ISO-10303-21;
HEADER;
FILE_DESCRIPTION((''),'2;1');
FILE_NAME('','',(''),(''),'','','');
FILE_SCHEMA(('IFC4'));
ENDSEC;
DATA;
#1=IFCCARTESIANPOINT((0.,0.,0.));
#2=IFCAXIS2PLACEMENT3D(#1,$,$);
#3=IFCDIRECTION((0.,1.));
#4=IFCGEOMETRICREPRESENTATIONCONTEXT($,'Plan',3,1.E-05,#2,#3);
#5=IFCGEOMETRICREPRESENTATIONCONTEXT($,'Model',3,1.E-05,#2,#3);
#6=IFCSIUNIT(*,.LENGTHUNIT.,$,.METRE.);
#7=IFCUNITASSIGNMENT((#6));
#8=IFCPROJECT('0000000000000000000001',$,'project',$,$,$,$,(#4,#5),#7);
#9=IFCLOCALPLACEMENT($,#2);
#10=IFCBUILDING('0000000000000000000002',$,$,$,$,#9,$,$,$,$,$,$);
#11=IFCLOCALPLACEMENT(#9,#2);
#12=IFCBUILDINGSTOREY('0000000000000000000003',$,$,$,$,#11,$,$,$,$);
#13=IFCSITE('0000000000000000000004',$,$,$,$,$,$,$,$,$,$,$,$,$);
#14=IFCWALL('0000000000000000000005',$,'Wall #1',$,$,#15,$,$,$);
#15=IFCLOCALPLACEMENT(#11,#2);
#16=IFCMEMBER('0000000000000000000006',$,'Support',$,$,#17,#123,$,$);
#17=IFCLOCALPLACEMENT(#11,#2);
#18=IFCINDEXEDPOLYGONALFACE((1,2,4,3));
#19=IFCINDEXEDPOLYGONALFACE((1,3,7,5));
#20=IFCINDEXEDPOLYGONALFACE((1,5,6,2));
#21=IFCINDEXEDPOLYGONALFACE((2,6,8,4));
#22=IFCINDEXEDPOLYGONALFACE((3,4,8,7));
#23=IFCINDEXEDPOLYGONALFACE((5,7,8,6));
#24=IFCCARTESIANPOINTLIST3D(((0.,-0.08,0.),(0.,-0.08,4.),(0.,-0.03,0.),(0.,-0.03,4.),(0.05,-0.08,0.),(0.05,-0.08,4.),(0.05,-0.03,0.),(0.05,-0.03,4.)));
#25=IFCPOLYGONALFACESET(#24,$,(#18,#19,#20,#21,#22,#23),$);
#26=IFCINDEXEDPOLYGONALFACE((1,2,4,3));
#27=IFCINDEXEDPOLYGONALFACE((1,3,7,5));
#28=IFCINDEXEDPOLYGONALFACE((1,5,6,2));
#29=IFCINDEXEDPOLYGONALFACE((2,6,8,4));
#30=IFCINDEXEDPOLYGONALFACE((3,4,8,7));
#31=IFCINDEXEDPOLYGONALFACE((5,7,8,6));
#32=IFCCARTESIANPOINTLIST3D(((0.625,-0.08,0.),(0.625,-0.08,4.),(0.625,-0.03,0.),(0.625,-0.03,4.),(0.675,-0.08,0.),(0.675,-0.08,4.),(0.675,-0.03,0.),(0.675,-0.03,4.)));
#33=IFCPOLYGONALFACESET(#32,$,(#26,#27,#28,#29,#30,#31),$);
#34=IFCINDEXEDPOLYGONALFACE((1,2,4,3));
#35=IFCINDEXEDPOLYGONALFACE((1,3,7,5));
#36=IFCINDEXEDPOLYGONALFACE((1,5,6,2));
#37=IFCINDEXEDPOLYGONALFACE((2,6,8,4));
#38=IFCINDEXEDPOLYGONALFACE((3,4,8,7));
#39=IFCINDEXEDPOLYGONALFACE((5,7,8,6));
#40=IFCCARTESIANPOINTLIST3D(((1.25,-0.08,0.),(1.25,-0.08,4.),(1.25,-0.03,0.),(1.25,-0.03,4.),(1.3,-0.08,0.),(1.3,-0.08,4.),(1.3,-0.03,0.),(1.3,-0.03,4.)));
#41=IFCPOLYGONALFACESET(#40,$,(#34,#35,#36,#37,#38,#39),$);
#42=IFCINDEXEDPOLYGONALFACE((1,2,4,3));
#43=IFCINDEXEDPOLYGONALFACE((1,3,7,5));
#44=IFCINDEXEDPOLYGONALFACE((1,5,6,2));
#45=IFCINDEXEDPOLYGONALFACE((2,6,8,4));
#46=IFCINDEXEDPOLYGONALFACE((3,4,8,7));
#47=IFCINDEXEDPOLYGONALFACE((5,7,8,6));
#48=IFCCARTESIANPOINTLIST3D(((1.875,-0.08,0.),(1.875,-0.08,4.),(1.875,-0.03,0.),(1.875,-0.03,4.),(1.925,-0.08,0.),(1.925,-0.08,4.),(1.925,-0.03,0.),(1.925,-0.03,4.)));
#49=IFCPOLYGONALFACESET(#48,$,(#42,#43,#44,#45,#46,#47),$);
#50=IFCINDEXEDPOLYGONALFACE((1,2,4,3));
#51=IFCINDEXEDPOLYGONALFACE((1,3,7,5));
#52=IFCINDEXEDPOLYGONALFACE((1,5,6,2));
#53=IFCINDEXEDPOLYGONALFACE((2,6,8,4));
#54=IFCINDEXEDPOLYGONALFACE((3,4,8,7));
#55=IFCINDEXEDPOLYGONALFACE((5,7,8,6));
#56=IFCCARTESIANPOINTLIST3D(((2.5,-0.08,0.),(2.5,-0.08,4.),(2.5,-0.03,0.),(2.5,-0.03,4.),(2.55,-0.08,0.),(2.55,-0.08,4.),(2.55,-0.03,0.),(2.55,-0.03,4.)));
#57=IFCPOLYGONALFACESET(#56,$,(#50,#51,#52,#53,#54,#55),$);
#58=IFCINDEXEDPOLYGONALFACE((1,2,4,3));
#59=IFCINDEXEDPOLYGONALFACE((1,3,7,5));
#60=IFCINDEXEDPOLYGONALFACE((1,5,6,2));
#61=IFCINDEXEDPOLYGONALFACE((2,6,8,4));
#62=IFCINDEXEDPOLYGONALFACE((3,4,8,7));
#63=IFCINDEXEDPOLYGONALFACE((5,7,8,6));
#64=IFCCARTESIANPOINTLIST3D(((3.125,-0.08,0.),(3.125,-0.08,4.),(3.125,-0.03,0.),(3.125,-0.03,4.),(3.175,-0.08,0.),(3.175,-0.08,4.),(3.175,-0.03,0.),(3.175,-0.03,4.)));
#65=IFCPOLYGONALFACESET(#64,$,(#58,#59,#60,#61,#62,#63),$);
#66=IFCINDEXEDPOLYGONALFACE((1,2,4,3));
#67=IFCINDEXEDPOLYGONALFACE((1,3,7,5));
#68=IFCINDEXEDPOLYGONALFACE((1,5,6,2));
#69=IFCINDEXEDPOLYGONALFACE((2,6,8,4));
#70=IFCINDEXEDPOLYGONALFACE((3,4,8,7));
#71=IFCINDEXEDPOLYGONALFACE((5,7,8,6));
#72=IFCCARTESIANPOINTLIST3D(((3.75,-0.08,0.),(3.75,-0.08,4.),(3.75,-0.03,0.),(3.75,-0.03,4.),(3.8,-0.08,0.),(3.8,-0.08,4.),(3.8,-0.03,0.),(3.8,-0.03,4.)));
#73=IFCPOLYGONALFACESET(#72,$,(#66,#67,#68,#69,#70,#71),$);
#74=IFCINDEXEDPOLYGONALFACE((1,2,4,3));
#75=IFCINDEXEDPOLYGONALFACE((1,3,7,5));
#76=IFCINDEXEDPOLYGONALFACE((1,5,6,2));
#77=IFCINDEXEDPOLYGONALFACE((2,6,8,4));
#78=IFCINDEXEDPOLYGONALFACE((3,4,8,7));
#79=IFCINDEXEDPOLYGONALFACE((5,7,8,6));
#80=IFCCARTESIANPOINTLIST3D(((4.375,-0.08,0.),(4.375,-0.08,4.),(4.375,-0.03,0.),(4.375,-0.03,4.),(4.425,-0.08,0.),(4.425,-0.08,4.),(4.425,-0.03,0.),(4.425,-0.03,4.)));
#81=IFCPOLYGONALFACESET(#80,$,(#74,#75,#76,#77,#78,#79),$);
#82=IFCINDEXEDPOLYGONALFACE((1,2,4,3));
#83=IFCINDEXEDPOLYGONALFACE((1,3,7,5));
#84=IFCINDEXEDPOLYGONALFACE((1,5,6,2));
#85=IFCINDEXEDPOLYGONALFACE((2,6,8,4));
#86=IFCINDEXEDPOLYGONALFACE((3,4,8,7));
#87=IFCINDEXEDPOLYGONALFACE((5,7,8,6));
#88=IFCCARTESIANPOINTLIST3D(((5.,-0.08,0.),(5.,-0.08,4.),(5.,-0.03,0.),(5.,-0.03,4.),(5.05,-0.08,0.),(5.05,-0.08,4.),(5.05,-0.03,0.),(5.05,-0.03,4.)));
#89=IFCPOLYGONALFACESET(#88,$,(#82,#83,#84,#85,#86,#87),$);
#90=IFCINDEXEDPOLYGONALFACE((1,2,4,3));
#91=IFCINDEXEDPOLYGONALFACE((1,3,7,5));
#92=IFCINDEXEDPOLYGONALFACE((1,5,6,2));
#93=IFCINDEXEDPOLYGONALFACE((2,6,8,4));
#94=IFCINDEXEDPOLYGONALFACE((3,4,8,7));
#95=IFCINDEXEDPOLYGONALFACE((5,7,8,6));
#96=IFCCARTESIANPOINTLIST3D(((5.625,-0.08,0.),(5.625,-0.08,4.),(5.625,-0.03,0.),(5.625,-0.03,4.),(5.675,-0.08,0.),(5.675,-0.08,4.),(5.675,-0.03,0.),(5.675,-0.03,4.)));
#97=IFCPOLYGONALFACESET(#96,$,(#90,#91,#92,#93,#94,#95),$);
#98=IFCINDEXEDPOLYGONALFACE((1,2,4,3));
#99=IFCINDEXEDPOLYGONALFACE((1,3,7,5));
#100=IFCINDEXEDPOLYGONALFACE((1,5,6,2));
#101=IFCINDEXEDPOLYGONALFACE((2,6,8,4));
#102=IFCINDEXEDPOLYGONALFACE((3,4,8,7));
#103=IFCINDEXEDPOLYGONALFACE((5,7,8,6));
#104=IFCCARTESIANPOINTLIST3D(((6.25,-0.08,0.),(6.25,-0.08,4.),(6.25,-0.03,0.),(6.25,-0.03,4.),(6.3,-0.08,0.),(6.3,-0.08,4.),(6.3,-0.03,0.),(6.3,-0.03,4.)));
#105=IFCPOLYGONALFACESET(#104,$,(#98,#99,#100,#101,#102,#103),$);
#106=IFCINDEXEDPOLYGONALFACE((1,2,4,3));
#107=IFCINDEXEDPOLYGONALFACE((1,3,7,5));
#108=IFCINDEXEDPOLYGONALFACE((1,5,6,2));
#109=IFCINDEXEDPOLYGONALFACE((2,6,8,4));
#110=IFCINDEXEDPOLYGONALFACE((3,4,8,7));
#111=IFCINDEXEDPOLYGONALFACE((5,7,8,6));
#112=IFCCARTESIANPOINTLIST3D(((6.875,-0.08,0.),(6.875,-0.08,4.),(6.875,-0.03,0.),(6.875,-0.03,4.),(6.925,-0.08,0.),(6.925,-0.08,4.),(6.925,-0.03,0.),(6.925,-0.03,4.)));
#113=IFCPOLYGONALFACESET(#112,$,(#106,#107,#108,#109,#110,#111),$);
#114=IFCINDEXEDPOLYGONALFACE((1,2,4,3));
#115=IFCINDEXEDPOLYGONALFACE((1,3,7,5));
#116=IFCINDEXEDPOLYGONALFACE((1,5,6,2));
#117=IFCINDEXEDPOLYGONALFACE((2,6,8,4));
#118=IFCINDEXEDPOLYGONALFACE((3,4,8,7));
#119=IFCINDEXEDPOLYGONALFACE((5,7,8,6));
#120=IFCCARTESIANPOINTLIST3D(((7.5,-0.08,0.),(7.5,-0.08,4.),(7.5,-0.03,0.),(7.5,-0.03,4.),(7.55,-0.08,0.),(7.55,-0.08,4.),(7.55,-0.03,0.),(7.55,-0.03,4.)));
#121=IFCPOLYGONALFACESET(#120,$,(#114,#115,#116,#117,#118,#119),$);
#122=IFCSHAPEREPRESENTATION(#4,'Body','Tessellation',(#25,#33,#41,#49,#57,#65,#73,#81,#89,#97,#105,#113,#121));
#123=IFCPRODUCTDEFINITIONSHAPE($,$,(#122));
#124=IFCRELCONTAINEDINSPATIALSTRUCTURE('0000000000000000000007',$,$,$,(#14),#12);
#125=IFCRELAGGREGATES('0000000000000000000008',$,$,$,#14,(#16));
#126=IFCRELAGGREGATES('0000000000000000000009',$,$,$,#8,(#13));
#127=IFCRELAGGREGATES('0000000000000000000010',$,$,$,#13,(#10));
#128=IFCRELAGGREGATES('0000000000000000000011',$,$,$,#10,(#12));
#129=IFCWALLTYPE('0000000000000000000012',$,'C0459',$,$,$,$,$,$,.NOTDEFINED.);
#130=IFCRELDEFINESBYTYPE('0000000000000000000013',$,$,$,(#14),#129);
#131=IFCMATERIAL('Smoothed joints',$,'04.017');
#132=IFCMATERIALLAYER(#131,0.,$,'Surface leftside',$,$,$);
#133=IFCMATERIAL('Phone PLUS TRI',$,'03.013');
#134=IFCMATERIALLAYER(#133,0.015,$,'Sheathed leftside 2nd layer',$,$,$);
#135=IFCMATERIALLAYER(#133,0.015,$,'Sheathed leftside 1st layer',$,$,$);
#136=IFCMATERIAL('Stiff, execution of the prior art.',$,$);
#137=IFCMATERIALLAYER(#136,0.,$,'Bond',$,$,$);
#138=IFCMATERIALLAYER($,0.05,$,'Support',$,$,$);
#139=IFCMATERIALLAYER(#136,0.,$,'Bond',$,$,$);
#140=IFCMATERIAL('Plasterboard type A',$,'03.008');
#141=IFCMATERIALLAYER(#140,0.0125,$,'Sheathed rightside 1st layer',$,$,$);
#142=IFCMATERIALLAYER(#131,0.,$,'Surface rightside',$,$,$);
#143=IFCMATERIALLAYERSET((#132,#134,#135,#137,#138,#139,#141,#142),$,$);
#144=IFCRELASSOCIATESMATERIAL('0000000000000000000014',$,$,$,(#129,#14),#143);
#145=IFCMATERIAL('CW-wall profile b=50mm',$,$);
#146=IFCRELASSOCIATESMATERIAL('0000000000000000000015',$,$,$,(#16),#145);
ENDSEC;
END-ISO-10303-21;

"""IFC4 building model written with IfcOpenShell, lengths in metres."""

from ifc_helpers import new_model, si_unit, direction, frame, frame_2d, origin, place, context, project, spatial, rectangle, extrude, material, layer, layer_set, type_object, element, aggregate, save


model = new_model("IFC4")

# Units and contexts
plan_context = context("Plan", 3, precision=1e-05, world=origin(), true_north=direction((0.0, 1.0)))
model_context = context("Model", 3, precision=1e-05, world=origin(), true_north=direction((0.0, 1.0)))
ifc_project = project(units=[si_unit("LENGTHUNIT", "METRE")], contexts=[plan_context, model_context])

# Site, building, storey
site = spatial("IfcSite", under=ifc_project)
building_placement = place(None, origin())
building = spatial("IfcBuilding", under=site, at=building_placement)
storey_placement = place(building_placement, origin())
storey = spatial("IfcBuildingStorey", under=building, at=storey_placement)

# Wall, member
ifc_material_1 = material(Name="Smoothed joints", Category="04.017")
ifc_layer_1 = layer(ifc_material_1, 0.0, Name="Surface leftside")
ifc_material_2 = material(Name="Phone PLUS TRI", Category="03.013")
ifc_layer_2 = layer(ifc_material_2, 0.015, Name="Sheathed leftside 2nd layer")
ifc_layer_3 = layer(ifc_material_2, 0.015, Name="Sheathed leftside 1st layer")
ifc_material_3 = material(Name="Stiff, execution of the prior art.")
ifc_layer_4 = layer(ifc_material_3, 0.0, Name="Bond")
ifc_layer_5 = layer(None, 0.05, Name="Support")
ifc_layer_6 = layer(ifc_material_3, 0.0, Name="Bond")
ifc_material_4 = material(Name="Plasterboard type A", Category="03.008")
ifc_layer_7 = layer(ifc_material_4, 0.0125, Name="Sheathed rightside 1st layer")
ifc_layer_8 = layer(ifc_material_1, 0.0, Name="Surface rightside")
ifc_layer_set = layer_set([ifc_layer_1, ifc_layer_2, ifc_layer_3, ifc_layer_4, ifc_layer_5, ifc_layer_6, ifc_layer_7, ifc_layer_8])
wall_type = type_object("IfcWallType", Name="C0459", PredefinedType="NOTDEFINED", material=ifc_layer_set)
wall_placement = place(None, frame((0.0, 0.0, 0.0), z_axis=(0.0, -1.0, 0.0), x_axis=(1.0, 0.0, 0.0)))
wall = element("IfcWall", 1, at=wall_placement, inside=storey, type_object=wall_type, material=ifc_layer_set, Name="Wall #1")
ifc_material_5 = material(Name="CW-wall profile b=50mm")
member_1_placement = place(wall_placement, origin())
member_1 = element("IfcMember", 2, at=member_1_placement, material=ifc_material_5, Name="Support", context=plan_context, shape_type="SweptSolid", body=[
    extrude(rectangle(XDim=0.05, YDim=0.05, at=frame_2d((0.025, 0.025), x_axis=(1.0, 0.0))), frame((0.0, 4.0, 0.03), z_axis=(0.0, -1.0, 0.0), x_axis=(1.0, 0.0, 0.0)), (0.0, 0.0, 1.0), 4.0),
    extrude(rectangle(XDim=0.05, YDim=0.05, at=frame_2d((0.025, 0.025), x_axis=(1.0, 0.0))), frame((0.625, 4.0, 0.03), z_axis=(0.0, -1.0, 0.0), x_axis=(1.0, 0.0, 0.0)), (0.0, 0.0, 1.0), 4.0),
    extrude(rectangle(XDim=0.05, YDim=0.05, at=frame_2d((0.025, 0.025), x_axis=(1.0, 0.0))), frame((1.25, 4.0, 0.03), z_axis=(0.0, -1.0, 0.0), x_axis=(1.0, 0.0, 0.0)), (0.0, 0.0, 1.0), 4.0),
    extrude(rectangle(XDim=0.05, YDim=0.05, at=frame_2d((0.025, 0.025), x_axis=(1.0, 0.0))), frame((1.875, 4.0, 0.03), z_axis=(0.0, -1.0, 0.0), x_axis=(1.0, 0.0, 0.0)), (0.0, 0.0, 1.0), 4.0),
    extrude(rectangle(XDim=0.05, YDim=0.05, at=frame_2d((0.025, 0.025), x_axis=(1.0, 0.0))), frame((2.5, 4.0, 0.03), z_axis=(0.0, -1.0, 0.0), x_axis=(1.0, 0.0, 0.0)), (0.0, 0.0, 1.0), 4.0),
    extrude(rectangle(XDim=0.05, YDim=0.05, at=frame_2d((0.025, 0.025), x_axis=(1.0, 0.0))), frame((3.125, 4.0, 0.03), z_axis=(0.0, -1.0, 0.0), x_axis=(1.0, 0.0, 0.0)), (0.0, 0.0, 1.0), 4.0),
    extrude(rectangle(XDim=0.05, YDim=0.05, at=frame_2d((0.025, 0.025), x_axis=(1.0, 0.0))), frame((3.75, 4.0, 0.03), z_axis=(0.0, -1.0, 0.0), x_axis=(1.0, 0.0, 0.0)), (0.0, 0.0, 1.0), 4.0),
    extrude(rectangle(XDim=0.05, YDim=0.05, at=frame_2d((0.025, 0.025), x_axis=(1.0, 0.0))), frame((4.375, 4.0, 0.03), z_axis=(0.0, -1.0, 0.0), x_axis=(1.0, 0.0, 0.0)), (0.0, 0.0, 1.0), 4.0),
    extrude(rectangle(XDim=0.05, YDim=0.05, at=frame_2d((0.025, 0.025), x_axis=(1.0, 0.0))), frame((5.0, 4.0, 0.03), z_axis=(0.0, -1.0, 0.0), x_axis=(1.0, 0.0, 0.0)), (0.0, 0.0, 1.0), 4.0),
    extrude(rectangle(XDim=0.05, YDim=0.05, at=frame_2d((0.025, 0.025), x_axis=(1.0, 0.0))), frame((5.625, 4.0, 0.03), z_axis=(0.0, -1.0, 0.0), x_axis=(1.0, 0.0, 0.0)), (0.0, 0.0, 1.0), 4.0),
    extrude(rectangle(XDim=0.05, YDim=0.05, at=frame_2d((0.025, 0.025), x_axis=(1.0, 0.0))), frame((6.25, 4.0, 0.03), z_axis=(0.0, -1.0, 0.0), x_axis=(1.0, 0.0, 0.0)), (0.0, 0.0, 1.0), 4.0),
    extrude(rectangle(XDim=0.05, YDim=0.05, at=frame_2d((0.025, 0.025), x_axis=(1.0, 0.0))), frame((6.875, 4.0, 0.03), z_axis=(0.0, -1.0, 0.0), x_axis=(1.0, 0.0, 0.0)), (0.0, 0.0, 1.0), 4.0),
    extrude(rectangle(XDim=0.05, YDim=0.05, at=frame_2d((0.025, 0.025), x_axis=(1.0, 0.0))), frame((7.5, 4.0, 0.03), z_axis=(0.0, -1.0, 0.0), x_axis=(1.0, 0.0, 0.0)), (0.0, 0.0, 1.0), 4.0),
])
aggregate(wall, [member_1])

save(model, "model.ifc")
